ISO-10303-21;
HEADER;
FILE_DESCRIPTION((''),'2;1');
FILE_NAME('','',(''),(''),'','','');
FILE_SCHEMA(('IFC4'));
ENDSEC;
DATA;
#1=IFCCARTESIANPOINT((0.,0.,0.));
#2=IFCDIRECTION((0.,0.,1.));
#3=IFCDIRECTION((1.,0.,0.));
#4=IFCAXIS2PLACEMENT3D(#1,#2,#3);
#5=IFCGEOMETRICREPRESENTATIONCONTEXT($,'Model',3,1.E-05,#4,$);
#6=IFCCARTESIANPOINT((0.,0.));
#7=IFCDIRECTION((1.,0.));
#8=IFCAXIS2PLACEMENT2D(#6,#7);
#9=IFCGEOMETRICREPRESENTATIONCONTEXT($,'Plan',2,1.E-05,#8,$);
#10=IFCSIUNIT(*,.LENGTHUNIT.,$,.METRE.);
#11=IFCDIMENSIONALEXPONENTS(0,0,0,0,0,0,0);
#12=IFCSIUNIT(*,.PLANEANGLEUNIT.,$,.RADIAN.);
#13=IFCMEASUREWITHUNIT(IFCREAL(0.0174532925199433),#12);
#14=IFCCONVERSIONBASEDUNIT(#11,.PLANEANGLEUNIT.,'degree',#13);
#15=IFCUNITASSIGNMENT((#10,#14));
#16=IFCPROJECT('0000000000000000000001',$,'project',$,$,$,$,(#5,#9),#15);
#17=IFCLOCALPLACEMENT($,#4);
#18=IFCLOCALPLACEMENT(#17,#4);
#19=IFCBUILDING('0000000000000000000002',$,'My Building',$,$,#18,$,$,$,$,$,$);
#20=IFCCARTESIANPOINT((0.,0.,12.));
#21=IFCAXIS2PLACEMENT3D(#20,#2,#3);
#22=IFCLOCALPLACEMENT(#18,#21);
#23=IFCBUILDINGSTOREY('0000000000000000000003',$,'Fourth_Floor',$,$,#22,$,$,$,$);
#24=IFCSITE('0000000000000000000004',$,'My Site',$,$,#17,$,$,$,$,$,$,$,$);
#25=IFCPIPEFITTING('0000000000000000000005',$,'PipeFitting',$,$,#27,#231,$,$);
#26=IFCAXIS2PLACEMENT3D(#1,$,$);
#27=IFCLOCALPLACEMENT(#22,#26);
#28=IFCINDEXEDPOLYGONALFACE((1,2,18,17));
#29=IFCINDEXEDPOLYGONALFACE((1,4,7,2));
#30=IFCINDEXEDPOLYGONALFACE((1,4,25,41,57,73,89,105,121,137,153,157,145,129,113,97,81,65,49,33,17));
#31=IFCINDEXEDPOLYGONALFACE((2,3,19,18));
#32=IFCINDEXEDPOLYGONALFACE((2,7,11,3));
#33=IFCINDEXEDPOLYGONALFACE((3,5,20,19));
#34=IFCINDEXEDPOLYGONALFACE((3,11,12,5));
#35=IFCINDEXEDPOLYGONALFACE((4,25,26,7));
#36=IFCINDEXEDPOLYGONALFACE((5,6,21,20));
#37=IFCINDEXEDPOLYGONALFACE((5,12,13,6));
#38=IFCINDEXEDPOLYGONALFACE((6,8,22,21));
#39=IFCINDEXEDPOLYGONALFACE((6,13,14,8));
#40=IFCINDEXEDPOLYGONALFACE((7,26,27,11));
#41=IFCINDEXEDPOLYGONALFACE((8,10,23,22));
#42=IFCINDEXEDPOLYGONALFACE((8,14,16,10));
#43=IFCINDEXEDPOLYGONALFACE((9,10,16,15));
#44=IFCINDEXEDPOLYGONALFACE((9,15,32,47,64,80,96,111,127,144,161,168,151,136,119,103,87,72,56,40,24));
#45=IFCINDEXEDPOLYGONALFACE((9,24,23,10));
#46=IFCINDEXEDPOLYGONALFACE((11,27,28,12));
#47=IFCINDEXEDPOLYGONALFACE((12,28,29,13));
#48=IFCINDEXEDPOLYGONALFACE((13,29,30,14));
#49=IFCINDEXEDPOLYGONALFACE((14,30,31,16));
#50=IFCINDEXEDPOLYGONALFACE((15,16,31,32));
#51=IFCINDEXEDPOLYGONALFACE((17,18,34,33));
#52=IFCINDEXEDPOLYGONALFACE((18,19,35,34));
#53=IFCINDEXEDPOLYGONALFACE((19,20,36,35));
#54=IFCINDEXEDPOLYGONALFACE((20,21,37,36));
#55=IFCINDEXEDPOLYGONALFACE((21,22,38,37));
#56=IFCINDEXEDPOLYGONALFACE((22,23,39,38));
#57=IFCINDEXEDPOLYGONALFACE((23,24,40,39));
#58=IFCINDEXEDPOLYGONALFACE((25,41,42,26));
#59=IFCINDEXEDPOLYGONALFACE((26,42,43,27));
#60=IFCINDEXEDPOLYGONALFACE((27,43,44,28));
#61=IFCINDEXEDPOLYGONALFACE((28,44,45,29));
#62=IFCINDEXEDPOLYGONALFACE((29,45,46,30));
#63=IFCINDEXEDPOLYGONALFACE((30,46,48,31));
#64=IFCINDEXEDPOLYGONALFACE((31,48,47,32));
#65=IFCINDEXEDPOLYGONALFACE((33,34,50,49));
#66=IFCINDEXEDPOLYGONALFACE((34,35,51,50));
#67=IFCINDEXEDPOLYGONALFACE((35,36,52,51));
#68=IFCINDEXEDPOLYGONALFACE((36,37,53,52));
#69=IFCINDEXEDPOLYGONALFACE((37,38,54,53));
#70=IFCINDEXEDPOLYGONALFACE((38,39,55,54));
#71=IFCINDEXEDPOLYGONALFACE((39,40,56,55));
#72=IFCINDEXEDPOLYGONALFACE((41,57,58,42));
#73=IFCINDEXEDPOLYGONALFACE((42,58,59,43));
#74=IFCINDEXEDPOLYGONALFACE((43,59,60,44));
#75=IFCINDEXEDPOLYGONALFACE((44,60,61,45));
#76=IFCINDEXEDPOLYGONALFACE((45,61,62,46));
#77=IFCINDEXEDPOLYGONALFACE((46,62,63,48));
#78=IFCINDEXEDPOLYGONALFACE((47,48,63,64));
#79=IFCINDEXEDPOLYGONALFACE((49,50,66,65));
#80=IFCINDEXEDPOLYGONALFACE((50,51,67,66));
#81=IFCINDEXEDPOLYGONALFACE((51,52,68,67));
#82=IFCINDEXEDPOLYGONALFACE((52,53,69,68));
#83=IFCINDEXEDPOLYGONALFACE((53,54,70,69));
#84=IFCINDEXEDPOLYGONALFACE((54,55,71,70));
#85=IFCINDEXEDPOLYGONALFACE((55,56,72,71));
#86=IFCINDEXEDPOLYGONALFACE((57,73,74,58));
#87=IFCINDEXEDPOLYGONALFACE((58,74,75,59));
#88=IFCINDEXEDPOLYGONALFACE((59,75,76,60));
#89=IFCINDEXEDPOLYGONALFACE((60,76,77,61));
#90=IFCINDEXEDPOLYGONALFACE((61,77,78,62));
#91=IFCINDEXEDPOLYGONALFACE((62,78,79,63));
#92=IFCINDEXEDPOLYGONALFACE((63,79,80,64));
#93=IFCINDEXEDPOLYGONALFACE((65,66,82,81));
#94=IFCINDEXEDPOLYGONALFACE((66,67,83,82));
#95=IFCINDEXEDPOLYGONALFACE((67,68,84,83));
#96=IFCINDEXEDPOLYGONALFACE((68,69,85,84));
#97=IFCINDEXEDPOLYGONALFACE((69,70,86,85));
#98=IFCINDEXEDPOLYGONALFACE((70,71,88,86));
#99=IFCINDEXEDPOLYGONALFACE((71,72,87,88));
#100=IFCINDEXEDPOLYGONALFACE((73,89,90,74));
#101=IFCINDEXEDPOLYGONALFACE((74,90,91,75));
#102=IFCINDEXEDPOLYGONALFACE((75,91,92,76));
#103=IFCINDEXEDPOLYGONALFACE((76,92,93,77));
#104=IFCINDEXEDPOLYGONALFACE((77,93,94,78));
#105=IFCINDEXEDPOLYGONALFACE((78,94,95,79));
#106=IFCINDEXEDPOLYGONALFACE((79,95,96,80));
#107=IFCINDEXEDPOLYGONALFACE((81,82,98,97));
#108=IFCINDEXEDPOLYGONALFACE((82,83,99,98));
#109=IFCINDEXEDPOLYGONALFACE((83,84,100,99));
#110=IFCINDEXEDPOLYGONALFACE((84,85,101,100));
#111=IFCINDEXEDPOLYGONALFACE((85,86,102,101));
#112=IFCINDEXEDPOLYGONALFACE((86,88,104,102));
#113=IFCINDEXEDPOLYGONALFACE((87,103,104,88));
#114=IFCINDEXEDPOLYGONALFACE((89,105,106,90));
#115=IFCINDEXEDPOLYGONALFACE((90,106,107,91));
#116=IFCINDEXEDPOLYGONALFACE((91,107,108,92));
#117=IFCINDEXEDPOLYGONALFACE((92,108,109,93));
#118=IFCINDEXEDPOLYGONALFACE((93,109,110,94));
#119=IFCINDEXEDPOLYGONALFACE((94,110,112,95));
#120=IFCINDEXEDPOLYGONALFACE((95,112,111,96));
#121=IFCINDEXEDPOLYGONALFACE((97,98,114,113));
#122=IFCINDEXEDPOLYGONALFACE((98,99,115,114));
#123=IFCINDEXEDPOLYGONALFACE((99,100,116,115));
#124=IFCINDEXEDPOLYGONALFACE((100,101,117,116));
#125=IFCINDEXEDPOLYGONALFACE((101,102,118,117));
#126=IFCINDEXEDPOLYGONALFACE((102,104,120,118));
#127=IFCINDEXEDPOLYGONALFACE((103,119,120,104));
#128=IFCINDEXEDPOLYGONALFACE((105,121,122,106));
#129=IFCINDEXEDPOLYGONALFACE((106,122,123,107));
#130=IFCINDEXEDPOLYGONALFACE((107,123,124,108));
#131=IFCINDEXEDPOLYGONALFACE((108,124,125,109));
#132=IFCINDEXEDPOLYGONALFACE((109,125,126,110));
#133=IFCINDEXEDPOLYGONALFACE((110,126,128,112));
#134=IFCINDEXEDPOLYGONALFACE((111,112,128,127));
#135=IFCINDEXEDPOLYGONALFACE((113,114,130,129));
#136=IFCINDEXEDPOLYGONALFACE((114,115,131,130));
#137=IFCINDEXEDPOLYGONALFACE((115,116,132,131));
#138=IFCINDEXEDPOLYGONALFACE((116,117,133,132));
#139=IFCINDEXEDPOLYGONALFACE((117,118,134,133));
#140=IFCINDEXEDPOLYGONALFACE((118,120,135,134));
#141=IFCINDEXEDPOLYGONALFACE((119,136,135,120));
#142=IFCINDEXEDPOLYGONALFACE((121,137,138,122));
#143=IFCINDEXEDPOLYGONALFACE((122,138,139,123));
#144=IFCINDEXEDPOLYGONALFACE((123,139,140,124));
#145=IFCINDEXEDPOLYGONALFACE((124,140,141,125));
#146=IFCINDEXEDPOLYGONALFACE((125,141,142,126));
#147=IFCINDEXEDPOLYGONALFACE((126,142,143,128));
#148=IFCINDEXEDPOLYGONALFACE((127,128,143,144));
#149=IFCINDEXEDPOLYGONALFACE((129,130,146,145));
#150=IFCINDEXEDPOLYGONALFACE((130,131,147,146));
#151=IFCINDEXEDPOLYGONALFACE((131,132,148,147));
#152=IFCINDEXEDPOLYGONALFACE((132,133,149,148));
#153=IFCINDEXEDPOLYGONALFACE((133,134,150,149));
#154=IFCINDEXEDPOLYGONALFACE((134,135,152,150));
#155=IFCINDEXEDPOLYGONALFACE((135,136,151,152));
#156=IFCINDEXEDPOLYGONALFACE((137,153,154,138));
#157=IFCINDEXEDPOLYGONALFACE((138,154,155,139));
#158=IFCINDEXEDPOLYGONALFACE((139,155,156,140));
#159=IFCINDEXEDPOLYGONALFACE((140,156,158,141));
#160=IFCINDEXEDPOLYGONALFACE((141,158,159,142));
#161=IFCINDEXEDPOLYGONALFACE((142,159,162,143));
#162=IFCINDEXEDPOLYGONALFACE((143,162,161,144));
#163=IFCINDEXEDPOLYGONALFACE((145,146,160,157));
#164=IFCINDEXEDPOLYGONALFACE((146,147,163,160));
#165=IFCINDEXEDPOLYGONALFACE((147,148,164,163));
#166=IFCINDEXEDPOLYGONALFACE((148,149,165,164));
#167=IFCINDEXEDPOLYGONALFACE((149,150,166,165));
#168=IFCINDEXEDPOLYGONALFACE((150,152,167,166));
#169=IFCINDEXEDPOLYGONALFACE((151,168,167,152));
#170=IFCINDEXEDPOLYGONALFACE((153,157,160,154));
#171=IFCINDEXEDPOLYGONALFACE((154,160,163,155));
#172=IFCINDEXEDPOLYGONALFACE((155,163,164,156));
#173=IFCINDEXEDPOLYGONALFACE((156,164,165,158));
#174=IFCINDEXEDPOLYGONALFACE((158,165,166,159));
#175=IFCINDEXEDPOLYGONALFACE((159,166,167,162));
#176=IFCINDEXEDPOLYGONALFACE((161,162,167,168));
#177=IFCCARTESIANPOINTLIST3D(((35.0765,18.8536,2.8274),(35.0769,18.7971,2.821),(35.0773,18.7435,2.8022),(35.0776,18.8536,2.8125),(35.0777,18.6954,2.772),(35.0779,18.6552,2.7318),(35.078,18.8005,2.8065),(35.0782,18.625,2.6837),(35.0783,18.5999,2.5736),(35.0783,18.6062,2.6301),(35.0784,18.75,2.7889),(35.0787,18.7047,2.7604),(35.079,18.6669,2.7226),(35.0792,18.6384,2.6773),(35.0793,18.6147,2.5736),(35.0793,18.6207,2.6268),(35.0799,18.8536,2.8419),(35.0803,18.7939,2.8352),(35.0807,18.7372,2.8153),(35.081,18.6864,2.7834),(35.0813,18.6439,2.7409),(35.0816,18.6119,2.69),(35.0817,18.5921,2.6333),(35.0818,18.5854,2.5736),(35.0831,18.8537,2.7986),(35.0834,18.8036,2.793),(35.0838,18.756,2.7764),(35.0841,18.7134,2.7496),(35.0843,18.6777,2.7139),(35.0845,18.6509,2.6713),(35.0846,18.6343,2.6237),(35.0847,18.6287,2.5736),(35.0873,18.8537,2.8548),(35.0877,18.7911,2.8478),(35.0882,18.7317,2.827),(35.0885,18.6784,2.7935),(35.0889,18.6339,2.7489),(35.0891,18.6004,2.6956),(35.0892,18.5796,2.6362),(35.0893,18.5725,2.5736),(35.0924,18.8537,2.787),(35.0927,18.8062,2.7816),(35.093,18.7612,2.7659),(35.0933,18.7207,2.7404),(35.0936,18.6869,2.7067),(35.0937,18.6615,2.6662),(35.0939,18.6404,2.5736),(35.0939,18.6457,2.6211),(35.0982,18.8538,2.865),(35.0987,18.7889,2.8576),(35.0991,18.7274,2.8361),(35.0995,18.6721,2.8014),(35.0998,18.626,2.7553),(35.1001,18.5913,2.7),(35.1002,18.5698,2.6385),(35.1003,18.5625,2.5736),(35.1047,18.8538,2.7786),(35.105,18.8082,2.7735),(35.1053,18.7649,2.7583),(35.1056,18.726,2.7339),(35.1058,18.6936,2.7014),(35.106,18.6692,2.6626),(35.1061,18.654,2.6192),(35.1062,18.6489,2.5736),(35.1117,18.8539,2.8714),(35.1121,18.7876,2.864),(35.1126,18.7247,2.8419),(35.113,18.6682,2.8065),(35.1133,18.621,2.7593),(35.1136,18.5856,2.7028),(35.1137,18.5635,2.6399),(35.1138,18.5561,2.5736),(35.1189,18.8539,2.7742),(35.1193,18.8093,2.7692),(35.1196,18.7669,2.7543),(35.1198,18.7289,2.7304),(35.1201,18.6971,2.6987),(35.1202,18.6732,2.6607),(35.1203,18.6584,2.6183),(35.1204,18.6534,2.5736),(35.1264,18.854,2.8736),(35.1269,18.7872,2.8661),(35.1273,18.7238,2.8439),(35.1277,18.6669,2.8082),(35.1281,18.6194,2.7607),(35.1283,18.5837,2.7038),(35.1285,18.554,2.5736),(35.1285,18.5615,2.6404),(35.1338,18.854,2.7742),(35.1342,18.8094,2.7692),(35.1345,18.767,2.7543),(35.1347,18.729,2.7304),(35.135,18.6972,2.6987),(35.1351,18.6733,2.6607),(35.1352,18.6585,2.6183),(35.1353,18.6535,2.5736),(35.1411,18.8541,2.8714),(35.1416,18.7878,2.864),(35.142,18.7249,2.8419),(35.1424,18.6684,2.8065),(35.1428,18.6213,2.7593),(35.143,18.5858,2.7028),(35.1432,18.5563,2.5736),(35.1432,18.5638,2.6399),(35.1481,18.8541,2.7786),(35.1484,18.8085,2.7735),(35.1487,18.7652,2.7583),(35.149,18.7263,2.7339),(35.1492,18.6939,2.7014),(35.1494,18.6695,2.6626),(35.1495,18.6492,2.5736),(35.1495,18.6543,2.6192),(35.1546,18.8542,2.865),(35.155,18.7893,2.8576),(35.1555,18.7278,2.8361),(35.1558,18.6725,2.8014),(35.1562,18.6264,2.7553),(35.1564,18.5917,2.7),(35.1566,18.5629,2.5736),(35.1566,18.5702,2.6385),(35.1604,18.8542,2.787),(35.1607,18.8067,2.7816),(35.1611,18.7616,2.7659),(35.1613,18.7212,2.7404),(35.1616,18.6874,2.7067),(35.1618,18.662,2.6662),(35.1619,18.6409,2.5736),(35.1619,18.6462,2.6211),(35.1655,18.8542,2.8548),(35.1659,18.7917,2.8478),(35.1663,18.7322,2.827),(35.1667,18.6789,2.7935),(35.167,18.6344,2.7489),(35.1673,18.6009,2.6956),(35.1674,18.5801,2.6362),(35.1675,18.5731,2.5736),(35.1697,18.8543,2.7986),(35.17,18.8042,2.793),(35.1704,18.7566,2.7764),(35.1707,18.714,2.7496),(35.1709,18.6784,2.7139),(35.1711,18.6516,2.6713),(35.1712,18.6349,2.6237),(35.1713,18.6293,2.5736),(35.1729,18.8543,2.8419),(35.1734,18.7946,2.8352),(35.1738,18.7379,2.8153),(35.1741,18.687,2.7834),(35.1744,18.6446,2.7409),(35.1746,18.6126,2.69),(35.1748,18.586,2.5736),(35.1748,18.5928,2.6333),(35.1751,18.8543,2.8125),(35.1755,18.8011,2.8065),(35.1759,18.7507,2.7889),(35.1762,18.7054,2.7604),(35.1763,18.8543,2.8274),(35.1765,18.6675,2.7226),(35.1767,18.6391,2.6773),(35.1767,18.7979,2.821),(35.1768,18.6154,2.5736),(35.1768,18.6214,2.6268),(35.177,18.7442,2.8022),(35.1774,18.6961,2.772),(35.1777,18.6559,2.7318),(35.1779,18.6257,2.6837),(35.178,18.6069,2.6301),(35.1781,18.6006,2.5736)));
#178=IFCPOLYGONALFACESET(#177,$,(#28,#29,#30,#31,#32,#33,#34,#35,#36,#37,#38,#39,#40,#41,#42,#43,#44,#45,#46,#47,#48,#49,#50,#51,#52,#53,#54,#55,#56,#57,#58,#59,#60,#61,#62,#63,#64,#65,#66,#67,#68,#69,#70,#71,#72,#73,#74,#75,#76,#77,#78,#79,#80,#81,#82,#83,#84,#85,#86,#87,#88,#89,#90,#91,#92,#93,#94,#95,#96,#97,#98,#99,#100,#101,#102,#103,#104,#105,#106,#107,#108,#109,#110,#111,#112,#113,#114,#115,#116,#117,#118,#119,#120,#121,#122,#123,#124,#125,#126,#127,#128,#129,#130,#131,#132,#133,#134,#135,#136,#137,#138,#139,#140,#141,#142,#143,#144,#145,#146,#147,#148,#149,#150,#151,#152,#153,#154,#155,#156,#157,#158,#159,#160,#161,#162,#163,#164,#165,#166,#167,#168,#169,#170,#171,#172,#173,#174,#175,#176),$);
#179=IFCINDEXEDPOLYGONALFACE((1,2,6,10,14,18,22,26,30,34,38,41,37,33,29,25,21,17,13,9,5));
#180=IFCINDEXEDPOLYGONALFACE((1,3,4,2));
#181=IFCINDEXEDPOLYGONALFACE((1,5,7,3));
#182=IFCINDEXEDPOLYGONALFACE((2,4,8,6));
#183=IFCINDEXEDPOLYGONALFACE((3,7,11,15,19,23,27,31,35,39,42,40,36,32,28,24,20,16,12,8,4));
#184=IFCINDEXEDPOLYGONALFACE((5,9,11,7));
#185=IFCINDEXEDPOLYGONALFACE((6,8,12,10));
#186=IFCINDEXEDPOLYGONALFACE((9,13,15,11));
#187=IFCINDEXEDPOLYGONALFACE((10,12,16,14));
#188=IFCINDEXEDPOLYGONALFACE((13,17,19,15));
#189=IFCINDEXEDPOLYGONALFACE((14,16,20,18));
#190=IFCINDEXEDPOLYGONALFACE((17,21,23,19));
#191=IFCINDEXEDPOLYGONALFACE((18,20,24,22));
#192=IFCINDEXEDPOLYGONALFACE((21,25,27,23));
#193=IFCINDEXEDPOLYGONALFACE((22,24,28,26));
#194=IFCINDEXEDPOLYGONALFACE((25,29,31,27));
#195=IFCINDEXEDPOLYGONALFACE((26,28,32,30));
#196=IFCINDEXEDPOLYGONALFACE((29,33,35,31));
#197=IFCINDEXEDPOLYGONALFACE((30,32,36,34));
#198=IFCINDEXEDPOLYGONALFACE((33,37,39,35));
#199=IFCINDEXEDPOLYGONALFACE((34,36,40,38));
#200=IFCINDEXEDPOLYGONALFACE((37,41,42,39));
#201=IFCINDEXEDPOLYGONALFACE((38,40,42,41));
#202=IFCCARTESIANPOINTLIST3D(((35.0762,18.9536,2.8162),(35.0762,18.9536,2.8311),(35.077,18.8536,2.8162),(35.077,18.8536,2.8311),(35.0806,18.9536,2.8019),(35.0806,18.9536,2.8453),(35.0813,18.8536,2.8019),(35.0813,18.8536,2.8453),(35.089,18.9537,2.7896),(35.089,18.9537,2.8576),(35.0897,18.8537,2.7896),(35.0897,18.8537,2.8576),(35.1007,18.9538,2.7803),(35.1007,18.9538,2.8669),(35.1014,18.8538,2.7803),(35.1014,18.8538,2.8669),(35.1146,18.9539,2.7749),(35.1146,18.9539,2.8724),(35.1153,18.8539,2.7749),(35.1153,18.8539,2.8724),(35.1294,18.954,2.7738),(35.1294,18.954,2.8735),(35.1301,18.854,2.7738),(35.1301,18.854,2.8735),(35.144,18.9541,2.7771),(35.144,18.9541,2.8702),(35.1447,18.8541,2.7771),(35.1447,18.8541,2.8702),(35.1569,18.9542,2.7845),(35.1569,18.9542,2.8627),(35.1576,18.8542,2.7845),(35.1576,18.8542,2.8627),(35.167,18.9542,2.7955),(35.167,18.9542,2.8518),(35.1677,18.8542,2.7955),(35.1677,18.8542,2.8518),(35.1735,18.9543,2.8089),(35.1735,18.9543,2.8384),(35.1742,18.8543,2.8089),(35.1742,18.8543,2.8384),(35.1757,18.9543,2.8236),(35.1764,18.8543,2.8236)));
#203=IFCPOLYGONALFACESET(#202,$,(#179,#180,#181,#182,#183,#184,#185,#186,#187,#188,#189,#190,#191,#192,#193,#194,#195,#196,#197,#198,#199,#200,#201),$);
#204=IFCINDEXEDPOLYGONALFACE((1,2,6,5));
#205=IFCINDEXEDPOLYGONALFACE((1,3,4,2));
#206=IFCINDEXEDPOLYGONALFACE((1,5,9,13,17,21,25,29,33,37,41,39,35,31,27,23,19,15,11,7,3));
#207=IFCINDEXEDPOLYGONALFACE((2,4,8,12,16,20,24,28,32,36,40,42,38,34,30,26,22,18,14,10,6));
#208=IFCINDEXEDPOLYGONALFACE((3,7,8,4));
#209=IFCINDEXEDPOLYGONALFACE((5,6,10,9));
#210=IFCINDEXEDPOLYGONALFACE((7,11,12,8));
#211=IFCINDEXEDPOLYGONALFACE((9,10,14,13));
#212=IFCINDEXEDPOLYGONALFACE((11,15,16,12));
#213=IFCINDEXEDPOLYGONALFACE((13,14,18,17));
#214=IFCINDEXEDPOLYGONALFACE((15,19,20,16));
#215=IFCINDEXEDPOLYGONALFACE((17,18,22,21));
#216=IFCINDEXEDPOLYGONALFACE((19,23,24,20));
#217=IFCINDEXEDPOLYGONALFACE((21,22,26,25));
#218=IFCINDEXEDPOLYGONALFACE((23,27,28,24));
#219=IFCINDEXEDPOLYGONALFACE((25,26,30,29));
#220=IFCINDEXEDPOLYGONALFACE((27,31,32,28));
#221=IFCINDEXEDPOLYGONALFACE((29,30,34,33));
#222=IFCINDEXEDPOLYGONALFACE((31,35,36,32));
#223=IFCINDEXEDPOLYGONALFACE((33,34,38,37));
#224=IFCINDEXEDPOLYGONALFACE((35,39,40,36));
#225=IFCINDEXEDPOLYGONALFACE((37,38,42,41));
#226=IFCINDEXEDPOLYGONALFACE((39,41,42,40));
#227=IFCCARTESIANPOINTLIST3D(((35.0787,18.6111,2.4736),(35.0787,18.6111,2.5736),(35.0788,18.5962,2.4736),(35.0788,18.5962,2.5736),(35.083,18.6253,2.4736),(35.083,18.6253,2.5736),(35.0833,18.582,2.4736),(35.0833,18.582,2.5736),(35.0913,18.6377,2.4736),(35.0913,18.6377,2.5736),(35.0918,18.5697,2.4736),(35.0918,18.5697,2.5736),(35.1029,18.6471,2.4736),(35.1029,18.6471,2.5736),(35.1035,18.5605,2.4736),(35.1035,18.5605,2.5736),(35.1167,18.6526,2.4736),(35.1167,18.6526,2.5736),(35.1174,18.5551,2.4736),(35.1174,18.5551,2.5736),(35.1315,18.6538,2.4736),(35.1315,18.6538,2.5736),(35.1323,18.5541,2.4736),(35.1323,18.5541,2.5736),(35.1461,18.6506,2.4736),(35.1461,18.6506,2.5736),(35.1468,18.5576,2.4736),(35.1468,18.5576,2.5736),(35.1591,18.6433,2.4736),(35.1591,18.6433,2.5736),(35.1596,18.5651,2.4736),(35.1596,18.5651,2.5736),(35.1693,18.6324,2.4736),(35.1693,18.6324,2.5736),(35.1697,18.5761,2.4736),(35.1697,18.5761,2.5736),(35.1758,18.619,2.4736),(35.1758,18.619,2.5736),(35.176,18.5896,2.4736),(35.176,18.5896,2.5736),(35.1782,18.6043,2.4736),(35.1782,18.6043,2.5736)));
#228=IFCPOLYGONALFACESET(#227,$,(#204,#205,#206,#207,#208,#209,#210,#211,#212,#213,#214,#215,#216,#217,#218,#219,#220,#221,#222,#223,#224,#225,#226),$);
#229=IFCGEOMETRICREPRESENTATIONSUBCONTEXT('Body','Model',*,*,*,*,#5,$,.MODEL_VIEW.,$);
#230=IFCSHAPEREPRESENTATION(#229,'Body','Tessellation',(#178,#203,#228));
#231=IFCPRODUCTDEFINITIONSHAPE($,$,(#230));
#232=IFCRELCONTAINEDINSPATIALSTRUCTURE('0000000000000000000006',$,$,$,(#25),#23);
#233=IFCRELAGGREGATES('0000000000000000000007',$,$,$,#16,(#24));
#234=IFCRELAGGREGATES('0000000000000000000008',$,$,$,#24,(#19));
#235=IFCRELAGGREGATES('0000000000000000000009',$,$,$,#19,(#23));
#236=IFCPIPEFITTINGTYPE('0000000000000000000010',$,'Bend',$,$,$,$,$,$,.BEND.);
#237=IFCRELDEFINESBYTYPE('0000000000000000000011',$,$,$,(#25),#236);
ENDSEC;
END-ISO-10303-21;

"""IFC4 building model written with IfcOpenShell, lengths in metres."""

from ifc_helpers import new_model, entity, si_unit, converted_unit, frame, origin_with_axes, origin_2d_with_axis, place, context, subcontext, project, spatial, circle, extrude, source, transform, mapped, type_object, type_shapes, element, save


model = new_model("IFC4")

# Units and contexts
model_context = context("Model", 3, precision=1e-05, world=origin_with_axes())
plan_context = context("Plan", 2, precision=1e-05, world=origin_2d_with_axis())
body_context_1 = subcontext(model_context, "Body", "Model", "MODEL_VIEW")
ifc_project = project(units=[si_unit("LENGTHUNIT", "METRE"), converted_unit("PLANEANGLEUNIT", "degree", entity("IfcReal", 0.0174532925199433), si_unit("PLANEANGLEUNIT", "RADIAN"), dimensions=[0, 0, 0, 0, 0, 0, 0])], contexts=[model_context, plan_context])

# Site, building, storey
site_placement = place(None, origin_with_axes())
site = spatial("IfcSite", under=ifc_project, at=site_placement, Name="My Site")
building_placement = place(site_placement, origin_with_axes())
building = spatial("IfcBuilding", under=site, at=building_placement, Name="My Building")
storey_placement = place(building_placement, frame((0.0, 0.0, 12.0), z_axis=(0.0, 0.0, 1.0), x_axis=(1.0, 0.0, 0.0)))
storey = spatial("IfcBuildingStorey", under=building, at=storey_placement, Name="Fourth_Floor")

# Pipe fitting
pipe_fitting_type = type_object("IfcPipeFittingType", Name="Bend", PredefinedType="BEND")
shared_shape_1 = source(origin_with_axes(), body_context_1, "Body", "SolidModel", [
    entity("IfcSweptDiskSolid", entity("IfcIndexedPolyCurve", entity("IfcCartesianPointList3D", [[0.0, 0.0, -0.1], [0.0, 0.0732, -0.2768], [0.0, 0.25, -0.35]]), [entity("IfcArcIndex", [1, 2, 3])]), 0.05),
    extrude(circle(Radius=0.05), origin_with_axes(), (0.0, 0.0, -1.0), 0.1),
    extrude(circle(Radius=0.05), frame((0.0, 0.25, -0.35), z_axis=(0.0, 1.0, 0.0), x_axis=(1.0, 0.0, 0.0)), (0.0, 0.0, 1.0), 0.1),
])
type_shapes(pipe_fitting_type, [shared_shape_1])
for number, where, z_axis, x_axis, name in (
    (1, (35.1257, 18.954, 2.8236), (-0.007084, 0.999975, 0.0), (0.999975, 0.007084, 0.0), "PipeFitting"),
):
    element("IfcPipeFitting", number, at=place(storey_placement, frame(where, z_axis=z_axis, x_axis=x_axis)), inside=storey, type_object=pipe_fitting_type, Name=name, context=body_context_1, shape_type="MappedRepresentation", body=[
        mapped(shared_shape_1, transform((0.0, 0.0, 0.0), x_axis=(1.0, 0.0, 0.0), y_axis=(0.0, 1.0, 0.0), z_axis=(0.0, 0.0, 1.0), scale=1.0)),
    ])

save(model, "model.ifc")
